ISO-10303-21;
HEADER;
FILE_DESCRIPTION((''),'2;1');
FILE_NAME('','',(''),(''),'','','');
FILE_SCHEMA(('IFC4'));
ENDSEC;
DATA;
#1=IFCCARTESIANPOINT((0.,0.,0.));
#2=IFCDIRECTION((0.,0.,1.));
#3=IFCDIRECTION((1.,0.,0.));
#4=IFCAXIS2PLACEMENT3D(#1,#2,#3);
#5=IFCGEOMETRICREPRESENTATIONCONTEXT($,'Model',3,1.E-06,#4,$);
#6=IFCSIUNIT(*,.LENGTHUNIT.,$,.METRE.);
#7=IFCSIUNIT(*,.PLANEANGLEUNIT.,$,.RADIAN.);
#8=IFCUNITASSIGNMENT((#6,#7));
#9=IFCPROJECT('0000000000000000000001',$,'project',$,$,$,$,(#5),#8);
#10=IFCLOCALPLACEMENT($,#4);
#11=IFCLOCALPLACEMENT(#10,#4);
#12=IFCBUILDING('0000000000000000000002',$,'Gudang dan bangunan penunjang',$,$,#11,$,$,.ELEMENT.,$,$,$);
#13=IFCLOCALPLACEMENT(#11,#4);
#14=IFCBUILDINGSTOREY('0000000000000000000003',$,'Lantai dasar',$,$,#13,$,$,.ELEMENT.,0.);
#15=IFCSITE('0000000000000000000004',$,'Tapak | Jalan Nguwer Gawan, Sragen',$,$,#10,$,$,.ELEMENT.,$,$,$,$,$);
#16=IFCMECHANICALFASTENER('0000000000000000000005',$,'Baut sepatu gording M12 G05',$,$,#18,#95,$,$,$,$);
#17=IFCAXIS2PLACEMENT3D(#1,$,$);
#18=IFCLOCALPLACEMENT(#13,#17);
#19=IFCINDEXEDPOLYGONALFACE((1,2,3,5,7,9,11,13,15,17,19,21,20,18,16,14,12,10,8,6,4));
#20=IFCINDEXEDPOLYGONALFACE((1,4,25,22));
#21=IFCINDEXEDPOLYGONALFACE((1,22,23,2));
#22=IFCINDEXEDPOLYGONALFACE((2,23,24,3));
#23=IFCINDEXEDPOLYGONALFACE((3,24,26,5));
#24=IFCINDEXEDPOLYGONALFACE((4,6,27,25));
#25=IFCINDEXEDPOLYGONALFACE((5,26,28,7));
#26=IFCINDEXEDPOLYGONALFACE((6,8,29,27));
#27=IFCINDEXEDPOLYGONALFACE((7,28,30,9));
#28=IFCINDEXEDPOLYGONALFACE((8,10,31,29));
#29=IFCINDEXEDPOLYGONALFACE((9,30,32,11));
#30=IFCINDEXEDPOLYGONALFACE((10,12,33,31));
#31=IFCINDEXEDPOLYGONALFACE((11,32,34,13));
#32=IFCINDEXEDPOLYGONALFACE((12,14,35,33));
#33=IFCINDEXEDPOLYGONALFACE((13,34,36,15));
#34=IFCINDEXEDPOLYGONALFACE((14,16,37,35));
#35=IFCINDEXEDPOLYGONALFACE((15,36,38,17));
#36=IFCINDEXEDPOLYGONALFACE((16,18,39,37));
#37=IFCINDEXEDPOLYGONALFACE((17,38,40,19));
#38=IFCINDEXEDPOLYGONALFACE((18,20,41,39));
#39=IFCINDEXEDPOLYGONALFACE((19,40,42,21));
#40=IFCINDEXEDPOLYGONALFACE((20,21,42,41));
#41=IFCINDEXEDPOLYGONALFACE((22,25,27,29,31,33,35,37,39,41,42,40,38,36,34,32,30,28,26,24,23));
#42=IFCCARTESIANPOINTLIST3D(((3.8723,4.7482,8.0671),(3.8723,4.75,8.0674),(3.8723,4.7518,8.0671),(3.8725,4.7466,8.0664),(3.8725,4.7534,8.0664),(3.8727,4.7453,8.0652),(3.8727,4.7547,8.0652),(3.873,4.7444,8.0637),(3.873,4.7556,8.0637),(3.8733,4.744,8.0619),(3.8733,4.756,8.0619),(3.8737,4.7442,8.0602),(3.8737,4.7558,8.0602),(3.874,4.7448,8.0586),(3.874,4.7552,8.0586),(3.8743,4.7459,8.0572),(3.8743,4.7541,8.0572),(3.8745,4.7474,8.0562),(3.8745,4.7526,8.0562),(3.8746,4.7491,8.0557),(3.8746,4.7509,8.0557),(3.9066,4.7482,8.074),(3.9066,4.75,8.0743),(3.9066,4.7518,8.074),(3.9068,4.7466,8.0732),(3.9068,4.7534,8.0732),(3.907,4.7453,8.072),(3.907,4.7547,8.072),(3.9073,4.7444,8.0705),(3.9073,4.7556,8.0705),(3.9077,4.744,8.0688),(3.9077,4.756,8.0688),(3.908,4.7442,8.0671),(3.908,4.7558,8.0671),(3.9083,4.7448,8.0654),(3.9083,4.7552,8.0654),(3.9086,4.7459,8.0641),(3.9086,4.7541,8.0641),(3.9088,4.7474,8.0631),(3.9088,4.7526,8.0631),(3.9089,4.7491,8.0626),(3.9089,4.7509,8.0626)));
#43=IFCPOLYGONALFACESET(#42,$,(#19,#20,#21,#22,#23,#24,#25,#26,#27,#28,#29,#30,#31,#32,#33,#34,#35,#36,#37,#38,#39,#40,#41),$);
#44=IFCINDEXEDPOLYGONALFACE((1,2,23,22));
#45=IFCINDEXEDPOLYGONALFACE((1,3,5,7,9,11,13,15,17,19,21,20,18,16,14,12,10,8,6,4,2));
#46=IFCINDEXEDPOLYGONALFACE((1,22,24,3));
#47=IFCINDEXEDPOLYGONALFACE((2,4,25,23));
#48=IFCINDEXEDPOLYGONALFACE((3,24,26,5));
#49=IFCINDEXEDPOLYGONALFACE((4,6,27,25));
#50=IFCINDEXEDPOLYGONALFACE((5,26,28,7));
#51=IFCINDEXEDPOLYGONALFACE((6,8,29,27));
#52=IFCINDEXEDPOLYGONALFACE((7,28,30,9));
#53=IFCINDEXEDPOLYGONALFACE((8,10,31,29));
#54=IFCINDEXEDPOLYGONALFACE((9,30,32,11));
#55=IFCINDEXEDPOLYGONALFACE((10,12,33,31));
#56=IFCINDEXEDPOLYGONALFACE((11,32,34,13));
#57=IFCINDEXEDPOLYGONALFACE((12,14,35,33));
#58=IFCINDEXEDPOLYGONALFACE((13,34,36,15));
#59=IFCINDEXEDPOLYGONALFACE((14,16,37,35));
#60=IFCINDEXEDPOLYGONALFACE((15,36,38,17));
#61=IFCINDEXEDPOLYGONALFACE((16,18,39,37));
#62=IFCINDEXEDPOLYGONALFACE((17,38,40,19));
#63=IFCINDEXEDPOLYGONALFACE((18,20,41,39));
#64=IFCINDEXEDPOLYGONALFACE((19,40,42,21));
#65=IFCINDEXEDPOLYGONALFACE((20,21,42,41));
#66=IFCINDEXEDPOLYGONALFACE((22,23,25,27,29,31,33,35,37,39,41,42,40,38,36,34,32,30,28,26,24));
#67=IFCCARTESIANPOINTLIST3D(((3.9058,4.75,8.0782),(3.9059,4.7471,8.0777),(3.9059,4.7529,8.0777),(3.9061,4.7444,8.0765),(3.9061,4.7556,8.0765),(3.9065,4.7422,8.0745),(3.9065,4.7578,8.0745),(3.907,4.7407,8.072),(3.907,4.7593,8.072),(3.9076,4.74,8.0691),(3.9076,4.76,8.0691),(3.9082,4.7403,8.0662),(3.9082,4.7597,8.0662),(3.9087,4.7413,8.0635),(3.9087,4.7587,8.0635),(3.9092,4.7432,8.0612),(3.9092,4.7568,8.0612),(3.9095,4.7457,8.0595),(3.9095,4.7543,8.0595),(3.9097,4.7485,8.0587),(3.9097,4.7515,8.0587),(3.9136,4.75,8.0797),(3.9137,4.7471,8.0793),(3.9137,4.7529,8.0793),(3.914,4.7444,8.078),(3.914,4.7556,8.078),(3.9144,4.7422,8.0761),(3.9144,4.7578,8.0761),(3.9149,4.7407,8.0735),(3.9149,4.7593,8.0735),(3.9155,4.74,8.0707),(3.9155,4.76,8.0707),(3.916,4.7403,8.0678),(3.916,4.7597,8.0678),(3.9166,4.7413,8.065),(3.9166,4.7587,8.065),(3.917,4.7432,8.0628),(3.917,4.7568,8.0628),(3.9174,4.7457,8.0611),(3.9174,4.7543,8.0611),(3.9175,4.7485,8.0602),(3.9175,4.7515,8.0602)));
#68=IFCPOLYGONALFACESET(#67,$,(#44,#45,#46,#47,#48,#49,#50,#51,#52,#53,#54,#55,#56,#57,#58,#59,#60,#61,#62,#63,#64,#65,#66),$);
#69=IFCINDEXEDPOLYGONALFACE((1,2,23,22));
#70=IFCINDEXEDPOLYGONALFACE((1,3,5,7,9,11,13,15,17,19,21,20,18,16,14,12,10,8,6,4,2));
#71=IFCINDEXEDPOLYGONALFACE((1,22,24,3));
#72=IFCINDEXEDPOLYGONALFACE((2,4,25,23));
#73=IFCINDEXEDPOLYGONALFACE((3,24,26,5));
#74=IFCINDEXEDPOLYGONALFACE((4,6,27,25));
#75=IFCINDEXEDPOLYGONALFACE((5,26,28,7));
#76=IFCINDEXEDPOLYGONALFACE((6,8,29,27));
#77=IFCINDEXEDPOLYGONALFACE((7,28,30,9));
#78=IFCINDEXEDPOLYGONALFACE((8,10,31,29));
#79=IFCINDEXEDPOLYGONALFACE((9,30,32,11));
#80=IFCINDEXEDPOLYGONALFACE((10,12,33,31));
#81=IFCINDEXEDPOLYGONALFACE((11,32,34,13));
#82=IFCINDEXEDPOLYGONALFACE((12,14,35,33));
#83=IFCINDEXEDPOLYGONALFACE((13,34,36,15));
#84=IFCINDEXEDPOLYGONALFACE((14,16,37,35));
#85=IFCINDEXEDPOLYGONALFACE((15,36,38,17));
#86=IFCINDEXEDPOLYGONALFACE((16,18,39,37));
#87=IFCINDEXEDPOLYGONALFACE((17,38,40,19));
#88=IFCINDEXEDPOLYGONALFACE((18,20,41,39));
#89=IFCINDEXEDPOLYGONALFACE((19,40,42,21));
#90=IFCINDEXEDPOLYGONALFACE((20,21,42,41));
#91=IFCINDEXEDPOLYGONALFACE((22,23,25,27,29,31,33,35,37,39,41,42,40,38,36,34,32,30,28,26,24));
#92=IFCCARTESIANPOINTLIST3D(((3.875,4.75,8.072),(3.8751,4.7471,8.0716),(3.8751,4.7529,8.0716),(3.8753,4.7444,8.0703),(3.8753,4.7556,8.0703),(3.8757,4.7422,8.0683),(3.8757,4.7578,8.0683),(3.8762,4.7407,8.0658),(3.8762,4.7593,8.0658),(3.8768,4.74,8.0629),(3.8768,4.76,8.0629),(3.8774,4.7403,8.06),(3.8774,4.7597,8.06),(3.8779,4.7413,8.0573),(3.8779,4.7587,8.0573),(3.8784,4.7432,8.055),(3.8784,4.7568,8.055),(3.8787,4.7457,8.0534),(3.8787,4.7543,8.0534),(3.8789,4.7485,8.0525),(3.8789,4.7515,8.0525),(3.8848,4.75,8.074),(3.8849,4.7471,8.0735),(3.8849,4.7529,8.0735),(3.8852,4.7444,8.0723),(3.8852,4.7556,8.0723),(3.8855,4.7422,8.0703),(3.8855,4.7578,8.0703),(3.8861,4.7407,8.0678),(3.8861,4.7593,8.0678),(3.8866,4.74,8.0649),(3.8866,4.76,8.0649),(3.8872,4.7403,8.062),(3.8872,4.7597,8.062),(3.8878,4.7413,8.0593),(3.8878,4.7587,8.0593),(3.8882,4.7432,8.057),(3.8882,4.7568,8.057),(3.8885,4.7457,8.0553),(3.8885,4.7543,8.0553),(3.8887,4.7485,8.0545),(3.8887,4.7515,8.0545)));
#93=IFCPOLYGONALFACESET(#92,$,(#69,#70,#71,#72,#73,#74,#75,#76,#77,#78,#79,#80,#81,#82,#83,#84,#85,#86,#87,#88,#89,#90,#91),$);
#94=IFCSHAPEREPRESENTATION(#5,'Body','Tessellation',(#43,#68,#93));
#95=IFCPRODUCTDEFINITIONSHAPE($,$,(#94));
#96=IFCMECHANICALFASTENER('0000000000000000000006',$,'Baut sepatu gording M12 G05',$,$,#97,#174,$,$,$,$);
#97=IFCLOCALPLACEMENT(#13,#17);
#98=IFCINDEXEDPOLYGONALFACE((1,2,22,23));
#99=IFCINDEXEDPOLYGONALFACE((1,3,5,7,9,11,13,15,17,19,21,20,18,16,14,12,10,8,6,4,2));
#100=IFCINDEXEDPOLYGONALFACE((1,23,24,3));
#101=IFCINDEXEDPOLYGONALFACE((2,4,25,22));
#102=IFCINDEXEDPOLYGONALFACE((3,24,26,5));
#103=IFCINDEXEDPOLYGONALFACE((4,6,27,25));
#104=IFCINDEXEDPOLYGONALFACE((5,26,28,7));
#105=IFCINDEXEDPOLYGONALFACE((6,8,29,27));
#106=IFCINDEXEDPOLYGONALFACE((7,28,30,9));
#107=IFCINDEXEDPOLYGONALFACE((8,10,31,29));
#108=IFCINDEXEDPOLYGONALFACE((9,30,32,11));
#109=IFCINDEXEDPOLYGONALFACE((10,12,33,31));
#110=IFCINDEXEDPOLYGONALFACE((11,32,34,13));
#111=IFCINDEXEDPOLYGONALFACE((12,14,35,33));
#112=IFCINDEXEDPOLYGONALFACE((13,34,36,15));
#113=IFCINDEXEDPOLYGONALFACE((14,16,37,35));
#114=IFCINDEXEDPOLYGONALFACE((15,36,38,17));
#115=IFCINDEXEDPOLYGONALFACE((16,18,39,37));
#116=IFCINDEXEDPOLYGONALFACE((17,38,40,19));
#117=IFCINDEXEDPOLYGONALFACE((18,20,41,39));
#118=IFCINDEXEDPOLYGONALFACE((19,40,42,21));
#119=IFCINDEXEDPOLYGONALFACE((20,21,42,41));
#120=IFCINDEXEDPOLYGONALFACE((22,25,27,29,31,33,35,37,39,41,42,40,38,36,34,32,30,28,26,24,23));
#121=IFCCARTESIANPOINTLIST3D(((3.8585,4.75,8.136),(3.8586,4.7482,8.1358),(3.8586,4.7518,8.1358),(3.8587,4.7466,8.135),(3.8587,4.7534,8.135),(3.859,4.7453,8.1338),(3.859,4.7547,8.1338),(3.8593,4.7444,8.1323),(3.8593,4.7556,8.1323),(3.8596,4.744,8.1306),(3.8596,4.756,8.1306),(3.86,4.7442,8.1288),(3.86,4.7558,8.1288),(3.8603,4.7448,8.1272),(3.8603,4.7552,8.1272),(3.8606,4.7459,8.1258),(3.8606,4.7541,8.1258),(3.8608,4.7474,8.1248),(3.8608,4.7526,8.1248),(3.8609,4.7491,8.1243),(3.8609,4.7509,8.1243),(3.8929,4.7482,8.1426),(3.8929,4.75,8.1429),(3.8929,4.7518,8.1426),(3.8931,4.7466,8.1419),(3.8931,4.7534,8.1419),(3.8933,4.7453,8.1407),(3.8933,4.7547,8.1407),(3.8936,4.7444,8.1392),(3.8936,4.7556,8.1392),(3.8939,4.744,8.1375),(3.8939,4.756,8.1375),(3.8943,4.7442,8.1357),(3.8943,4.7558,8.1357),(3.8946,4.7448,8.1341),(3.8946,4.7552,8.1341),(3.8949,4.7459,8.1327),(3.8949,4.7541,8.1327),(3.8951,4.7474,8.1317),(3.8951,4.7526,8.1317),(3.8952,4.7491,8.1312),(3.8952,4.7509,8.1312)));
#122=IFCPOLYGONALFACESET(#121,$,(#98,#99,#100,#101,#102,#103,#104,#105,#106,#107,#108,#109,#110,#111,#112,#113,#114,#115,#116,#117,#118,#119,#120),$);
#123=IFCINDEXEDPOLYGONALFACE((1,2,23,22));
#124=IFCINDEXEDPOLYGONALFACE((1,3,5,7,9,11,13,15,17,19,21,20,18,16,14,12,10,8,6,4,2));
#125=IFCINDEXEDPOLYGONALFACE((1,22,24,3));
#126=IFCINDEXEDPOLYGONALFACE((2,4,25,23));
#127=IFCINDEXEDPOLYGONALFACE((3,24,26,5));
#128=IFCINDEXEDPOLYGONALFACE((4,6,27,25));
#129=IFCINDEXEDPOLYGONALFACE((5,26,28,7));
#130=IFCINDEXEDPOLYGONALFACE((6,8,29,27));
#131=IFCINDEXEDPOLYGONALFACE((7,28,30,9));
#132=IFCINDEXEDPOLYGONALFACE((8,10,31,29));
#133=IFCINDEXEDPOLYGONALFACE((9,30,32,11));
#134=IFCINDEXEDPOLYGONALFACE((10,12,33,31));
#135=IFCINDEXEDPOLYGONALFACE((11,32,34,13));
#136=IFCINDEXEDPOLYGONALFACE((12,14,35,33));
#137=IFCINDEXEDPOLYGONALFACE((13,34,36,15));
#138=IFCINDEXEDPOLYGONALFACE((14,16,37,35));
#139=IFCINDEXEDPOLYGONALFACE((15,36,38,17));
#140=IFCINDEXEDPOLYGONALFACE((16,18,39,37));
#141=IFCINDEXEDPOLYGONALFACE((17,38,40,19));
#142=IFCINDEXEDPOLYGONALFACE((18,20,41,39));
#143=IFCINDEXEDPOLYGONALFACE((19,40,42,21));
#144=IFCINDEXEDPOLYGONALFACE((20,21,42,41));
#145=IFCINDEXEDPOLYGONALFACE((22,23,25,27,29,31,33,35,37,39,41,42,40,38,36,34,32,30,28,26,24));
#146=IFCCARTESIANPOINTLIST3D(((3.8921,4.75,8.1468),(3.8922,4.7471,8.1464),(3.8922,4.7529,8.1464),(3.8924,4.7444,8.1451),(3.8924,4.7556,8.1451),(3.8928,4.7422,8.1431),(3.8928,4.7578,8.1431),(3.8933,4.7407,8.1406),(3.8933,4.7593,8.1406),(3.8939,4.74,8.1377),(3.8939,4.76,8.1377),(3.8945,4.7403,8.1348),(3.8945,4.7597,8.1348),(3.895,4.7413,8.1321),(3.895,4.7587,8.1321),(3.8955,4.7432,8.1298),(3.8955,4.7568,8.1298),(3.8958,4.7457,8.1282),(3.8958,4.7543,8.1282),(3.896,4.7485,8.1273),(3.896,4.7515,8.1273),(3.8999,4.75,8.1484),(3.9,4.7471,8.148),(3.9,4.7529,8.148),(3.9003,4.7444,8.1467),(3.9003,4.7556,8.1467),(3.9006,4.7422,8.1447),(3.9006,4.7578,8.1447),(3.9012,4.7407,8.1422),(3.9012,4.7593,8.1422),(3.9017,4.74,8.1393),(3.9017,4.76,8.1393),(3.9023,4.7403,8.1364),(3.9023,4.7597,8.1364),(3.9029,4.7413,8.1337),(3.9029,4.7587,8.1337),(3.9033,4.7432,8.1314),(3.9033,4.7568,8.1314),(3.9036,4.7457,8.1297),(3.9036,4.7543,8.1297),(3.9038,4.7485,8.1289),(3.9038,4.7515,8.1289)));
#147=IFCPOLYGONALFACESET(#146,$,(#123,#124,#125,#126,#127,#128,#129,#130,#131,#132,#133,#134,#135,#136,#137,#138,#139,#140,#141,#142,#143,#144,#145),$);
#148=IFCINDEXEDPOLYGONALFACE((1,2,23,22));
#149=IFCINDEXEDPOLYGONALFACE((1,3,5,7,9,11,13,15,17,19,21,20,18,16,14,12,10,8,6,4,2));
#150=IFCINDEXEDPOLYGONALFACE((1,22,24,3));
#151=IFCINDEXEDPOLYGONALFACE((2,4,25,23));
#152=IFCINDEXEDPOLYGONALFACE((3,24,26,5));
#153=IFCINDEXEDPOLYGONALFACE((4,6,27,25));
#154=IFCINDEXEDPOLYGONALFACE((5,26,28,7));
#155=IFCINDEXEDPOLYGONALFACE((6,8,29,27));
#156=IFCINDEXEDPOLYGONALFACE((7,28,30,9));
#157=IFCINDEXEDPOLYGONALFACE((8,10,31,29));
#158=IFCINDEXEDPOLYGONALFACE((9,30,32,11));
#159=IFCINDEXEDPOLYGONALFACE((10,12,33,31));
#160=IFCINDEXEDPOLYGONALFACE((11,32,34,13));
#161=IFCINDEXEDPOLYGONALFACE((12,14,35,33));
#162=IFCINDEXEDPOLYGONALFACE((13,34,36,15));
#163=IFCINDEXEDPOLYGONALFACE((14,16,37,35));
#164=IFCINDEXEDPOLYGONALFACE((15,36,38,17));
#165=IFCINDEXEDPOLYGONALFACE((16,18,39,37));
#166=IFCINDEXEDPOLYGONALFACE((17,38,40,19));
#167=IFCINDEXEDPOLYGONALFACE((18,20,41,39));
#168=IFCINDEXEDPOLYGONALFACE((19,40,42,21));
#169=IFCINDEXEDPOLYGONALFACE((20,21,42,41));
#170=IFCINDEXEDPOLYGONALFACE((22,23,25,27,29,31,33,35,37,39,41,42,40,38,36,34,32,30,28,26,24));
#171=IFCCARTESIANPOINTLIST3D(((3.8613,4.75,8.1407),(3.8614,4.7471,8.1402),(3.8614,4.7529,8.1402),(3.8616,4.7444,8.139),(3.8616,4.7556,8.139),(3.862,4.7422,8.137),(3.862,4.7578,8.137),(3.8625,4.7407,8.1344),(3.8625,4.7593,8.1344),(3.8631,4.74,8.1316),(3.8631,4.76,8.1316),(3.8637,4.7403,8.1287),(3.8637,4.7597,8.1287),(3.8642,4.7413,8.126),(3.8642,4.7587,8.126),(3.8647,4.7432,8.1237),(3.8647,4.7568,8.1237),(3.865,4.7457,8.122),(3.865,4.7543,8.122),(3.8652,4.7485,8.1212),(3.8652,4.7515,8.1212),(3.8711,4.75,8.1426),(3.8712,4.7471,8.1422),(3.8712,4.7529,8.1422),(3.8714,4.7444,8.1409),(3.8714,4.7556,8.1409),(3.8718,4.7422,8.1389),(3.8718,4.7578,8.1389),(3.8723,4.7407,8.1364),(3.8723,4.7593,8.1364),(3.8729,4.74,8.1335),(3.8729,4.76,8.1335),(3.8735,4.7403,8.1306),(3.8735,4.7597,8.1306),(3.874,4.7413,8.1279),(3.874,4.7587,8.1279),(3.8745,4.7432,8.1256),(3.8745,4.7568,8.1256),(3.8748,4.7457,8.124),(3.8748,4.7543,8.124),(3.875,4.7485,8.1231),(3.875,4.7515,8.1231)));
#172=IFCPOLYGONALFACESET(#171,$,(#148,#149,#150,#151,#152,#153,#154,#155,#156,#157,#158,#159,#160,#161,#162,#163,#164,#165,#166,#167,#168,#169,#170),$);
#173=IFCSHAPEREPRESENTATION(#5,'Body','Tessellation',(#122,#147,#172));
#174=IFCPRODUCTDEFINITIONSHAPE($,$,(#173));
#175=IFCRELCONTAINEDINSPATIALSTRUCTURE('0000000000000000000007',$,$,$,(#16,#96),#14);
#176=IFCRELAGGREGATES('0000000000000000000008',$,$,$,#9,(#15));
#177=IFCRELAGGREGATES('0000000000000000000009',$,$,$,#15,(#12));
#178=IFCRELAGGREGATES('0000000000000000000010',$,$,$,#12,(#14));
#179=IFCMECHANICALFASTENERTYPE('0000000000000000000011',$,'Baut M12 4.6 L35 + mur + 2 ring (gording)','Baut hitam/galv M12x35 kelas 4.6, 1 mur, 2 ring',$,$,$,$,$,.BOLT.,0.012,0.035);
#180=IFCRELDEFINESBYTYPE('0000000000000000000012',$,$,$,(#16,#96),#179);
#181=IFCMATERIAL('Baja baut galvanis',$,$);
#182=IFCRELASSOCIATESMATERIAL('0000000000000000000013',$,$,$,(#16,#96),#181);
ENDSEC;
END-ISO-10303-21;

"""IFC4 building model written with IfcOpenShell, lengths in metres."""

from ifc_helpers import new_model, si_unit, frame, origin_with_axes, place, context, project, spatial, circle, extrude, source, transform, mapped, material, type_object, type_shapes, element, save


model = new_model("IFC4")

# Units and contexts
model_context = context("Model", 3, precision=1e-06, world=origin_with_axes())
ifc_project = project(units=[si_unit("LENGTHUNIT", "METRE"), si_unit("PLANEANGLEUNIT", "RADIAN")], contexts=[model_context])

# Site, building, storey
site_placement = place(None, origin_with_axes())
site = spatial("IfcSite", under=ifc_project, at=site_placement, Name="Tapak | Jalan Nguwer Gawan, Sragen", CompositionType="ELEMENT")
building_placement = place(site_placement, origin_with_axes())
building = spatial("IfcBuilding", under=site, at=building_placement, Name="Gudang dan bangunan penunjang", CompositionType="ELEMENT")
storey_placement = place(building_placement, origin_with_axes())
storey = spatial("IfcBuildingStorey", under=building, at=storey_placement, Name="Lantai dasar", CompositionType="ELEMENT", Elevation=0.0)

# Shared definitions
placement = place(None, origin_with_axes())

# Mechanical fasteners
ifc_material_1 = material(Name="Baja baut galvanis")
mechanical_fastener_type = type_object("IfcMechanicalFastenerType", Name="Baut M12 4.6 L35 + mur + 2 ring (gording)", Description="Baut hitam/galv M12x35 kelas 4.6, 1 mur, 2 ring", NominalDiameter=0.012, NominalLength=0.035, PredefinedType="BOLT")
shared_shape = source(origin_with_axes(), model_context, "Body", "SweptSolid", [
    extrude(circle(Radius=0.006), origin_with_axes(), (0.0, 0.0, 1.0), 0.035),
    extrude(circle(Radius=0.01), frame((0.0, 0.0, -0.008), z_axis=(0.0, 0.0, 1.0), x_axis=(1.0, 0.0, 0.0)), (0.0, 0.0, 1.0), 0.008),
    extrude(circle(Radius=0.01), frame((0.0, 0.0, 0.0214), z_axis=(0.0, 0.0, 1.0), x_axis=(1.0, 0.0, 0.0)), (0.0, 0.0, 1.0), 0.01),
])
type_shapes(mechanical_fastener_type, [shared_shape])
element("IfcMechanicalFastener", 1, at=placement, inside=storey, type_object=mechanical_fastener_type, material=ifc_material_1, Name="Baut sepatu gording M12 G05", context=model_context, shape_type="MappedRepresentation", body=[
    mapped(shared_shape, transform((3.9078, 4.75, 8.0684), x_axis=(-0.196116, 0.0, 0.980581), y_axis=(0.0, 1.0, 0.0), z_axis=(-0.980581, 0.0, -0.196116), scale=1.0)),
])
element("IfcMechanicalFastener", 2, at=placement, inside=storey, type_object=mechanical_fastener_type, material=ifc_material_1, Name="Baut sepatu gording M12 G05", context=model_context, shape_type="MappedRepresentation", body=[
    mapped(shared_shape, transform((3.894, 4.75, 8.137), x_axis=(-0.196116, 0.0, 0.980581), y_axis=(0.0, 1.0, 0.0), z_axis=(-0.980581, 0.0, -0.196116), scale=1.0)),
])

save(model, "model.ifc")
